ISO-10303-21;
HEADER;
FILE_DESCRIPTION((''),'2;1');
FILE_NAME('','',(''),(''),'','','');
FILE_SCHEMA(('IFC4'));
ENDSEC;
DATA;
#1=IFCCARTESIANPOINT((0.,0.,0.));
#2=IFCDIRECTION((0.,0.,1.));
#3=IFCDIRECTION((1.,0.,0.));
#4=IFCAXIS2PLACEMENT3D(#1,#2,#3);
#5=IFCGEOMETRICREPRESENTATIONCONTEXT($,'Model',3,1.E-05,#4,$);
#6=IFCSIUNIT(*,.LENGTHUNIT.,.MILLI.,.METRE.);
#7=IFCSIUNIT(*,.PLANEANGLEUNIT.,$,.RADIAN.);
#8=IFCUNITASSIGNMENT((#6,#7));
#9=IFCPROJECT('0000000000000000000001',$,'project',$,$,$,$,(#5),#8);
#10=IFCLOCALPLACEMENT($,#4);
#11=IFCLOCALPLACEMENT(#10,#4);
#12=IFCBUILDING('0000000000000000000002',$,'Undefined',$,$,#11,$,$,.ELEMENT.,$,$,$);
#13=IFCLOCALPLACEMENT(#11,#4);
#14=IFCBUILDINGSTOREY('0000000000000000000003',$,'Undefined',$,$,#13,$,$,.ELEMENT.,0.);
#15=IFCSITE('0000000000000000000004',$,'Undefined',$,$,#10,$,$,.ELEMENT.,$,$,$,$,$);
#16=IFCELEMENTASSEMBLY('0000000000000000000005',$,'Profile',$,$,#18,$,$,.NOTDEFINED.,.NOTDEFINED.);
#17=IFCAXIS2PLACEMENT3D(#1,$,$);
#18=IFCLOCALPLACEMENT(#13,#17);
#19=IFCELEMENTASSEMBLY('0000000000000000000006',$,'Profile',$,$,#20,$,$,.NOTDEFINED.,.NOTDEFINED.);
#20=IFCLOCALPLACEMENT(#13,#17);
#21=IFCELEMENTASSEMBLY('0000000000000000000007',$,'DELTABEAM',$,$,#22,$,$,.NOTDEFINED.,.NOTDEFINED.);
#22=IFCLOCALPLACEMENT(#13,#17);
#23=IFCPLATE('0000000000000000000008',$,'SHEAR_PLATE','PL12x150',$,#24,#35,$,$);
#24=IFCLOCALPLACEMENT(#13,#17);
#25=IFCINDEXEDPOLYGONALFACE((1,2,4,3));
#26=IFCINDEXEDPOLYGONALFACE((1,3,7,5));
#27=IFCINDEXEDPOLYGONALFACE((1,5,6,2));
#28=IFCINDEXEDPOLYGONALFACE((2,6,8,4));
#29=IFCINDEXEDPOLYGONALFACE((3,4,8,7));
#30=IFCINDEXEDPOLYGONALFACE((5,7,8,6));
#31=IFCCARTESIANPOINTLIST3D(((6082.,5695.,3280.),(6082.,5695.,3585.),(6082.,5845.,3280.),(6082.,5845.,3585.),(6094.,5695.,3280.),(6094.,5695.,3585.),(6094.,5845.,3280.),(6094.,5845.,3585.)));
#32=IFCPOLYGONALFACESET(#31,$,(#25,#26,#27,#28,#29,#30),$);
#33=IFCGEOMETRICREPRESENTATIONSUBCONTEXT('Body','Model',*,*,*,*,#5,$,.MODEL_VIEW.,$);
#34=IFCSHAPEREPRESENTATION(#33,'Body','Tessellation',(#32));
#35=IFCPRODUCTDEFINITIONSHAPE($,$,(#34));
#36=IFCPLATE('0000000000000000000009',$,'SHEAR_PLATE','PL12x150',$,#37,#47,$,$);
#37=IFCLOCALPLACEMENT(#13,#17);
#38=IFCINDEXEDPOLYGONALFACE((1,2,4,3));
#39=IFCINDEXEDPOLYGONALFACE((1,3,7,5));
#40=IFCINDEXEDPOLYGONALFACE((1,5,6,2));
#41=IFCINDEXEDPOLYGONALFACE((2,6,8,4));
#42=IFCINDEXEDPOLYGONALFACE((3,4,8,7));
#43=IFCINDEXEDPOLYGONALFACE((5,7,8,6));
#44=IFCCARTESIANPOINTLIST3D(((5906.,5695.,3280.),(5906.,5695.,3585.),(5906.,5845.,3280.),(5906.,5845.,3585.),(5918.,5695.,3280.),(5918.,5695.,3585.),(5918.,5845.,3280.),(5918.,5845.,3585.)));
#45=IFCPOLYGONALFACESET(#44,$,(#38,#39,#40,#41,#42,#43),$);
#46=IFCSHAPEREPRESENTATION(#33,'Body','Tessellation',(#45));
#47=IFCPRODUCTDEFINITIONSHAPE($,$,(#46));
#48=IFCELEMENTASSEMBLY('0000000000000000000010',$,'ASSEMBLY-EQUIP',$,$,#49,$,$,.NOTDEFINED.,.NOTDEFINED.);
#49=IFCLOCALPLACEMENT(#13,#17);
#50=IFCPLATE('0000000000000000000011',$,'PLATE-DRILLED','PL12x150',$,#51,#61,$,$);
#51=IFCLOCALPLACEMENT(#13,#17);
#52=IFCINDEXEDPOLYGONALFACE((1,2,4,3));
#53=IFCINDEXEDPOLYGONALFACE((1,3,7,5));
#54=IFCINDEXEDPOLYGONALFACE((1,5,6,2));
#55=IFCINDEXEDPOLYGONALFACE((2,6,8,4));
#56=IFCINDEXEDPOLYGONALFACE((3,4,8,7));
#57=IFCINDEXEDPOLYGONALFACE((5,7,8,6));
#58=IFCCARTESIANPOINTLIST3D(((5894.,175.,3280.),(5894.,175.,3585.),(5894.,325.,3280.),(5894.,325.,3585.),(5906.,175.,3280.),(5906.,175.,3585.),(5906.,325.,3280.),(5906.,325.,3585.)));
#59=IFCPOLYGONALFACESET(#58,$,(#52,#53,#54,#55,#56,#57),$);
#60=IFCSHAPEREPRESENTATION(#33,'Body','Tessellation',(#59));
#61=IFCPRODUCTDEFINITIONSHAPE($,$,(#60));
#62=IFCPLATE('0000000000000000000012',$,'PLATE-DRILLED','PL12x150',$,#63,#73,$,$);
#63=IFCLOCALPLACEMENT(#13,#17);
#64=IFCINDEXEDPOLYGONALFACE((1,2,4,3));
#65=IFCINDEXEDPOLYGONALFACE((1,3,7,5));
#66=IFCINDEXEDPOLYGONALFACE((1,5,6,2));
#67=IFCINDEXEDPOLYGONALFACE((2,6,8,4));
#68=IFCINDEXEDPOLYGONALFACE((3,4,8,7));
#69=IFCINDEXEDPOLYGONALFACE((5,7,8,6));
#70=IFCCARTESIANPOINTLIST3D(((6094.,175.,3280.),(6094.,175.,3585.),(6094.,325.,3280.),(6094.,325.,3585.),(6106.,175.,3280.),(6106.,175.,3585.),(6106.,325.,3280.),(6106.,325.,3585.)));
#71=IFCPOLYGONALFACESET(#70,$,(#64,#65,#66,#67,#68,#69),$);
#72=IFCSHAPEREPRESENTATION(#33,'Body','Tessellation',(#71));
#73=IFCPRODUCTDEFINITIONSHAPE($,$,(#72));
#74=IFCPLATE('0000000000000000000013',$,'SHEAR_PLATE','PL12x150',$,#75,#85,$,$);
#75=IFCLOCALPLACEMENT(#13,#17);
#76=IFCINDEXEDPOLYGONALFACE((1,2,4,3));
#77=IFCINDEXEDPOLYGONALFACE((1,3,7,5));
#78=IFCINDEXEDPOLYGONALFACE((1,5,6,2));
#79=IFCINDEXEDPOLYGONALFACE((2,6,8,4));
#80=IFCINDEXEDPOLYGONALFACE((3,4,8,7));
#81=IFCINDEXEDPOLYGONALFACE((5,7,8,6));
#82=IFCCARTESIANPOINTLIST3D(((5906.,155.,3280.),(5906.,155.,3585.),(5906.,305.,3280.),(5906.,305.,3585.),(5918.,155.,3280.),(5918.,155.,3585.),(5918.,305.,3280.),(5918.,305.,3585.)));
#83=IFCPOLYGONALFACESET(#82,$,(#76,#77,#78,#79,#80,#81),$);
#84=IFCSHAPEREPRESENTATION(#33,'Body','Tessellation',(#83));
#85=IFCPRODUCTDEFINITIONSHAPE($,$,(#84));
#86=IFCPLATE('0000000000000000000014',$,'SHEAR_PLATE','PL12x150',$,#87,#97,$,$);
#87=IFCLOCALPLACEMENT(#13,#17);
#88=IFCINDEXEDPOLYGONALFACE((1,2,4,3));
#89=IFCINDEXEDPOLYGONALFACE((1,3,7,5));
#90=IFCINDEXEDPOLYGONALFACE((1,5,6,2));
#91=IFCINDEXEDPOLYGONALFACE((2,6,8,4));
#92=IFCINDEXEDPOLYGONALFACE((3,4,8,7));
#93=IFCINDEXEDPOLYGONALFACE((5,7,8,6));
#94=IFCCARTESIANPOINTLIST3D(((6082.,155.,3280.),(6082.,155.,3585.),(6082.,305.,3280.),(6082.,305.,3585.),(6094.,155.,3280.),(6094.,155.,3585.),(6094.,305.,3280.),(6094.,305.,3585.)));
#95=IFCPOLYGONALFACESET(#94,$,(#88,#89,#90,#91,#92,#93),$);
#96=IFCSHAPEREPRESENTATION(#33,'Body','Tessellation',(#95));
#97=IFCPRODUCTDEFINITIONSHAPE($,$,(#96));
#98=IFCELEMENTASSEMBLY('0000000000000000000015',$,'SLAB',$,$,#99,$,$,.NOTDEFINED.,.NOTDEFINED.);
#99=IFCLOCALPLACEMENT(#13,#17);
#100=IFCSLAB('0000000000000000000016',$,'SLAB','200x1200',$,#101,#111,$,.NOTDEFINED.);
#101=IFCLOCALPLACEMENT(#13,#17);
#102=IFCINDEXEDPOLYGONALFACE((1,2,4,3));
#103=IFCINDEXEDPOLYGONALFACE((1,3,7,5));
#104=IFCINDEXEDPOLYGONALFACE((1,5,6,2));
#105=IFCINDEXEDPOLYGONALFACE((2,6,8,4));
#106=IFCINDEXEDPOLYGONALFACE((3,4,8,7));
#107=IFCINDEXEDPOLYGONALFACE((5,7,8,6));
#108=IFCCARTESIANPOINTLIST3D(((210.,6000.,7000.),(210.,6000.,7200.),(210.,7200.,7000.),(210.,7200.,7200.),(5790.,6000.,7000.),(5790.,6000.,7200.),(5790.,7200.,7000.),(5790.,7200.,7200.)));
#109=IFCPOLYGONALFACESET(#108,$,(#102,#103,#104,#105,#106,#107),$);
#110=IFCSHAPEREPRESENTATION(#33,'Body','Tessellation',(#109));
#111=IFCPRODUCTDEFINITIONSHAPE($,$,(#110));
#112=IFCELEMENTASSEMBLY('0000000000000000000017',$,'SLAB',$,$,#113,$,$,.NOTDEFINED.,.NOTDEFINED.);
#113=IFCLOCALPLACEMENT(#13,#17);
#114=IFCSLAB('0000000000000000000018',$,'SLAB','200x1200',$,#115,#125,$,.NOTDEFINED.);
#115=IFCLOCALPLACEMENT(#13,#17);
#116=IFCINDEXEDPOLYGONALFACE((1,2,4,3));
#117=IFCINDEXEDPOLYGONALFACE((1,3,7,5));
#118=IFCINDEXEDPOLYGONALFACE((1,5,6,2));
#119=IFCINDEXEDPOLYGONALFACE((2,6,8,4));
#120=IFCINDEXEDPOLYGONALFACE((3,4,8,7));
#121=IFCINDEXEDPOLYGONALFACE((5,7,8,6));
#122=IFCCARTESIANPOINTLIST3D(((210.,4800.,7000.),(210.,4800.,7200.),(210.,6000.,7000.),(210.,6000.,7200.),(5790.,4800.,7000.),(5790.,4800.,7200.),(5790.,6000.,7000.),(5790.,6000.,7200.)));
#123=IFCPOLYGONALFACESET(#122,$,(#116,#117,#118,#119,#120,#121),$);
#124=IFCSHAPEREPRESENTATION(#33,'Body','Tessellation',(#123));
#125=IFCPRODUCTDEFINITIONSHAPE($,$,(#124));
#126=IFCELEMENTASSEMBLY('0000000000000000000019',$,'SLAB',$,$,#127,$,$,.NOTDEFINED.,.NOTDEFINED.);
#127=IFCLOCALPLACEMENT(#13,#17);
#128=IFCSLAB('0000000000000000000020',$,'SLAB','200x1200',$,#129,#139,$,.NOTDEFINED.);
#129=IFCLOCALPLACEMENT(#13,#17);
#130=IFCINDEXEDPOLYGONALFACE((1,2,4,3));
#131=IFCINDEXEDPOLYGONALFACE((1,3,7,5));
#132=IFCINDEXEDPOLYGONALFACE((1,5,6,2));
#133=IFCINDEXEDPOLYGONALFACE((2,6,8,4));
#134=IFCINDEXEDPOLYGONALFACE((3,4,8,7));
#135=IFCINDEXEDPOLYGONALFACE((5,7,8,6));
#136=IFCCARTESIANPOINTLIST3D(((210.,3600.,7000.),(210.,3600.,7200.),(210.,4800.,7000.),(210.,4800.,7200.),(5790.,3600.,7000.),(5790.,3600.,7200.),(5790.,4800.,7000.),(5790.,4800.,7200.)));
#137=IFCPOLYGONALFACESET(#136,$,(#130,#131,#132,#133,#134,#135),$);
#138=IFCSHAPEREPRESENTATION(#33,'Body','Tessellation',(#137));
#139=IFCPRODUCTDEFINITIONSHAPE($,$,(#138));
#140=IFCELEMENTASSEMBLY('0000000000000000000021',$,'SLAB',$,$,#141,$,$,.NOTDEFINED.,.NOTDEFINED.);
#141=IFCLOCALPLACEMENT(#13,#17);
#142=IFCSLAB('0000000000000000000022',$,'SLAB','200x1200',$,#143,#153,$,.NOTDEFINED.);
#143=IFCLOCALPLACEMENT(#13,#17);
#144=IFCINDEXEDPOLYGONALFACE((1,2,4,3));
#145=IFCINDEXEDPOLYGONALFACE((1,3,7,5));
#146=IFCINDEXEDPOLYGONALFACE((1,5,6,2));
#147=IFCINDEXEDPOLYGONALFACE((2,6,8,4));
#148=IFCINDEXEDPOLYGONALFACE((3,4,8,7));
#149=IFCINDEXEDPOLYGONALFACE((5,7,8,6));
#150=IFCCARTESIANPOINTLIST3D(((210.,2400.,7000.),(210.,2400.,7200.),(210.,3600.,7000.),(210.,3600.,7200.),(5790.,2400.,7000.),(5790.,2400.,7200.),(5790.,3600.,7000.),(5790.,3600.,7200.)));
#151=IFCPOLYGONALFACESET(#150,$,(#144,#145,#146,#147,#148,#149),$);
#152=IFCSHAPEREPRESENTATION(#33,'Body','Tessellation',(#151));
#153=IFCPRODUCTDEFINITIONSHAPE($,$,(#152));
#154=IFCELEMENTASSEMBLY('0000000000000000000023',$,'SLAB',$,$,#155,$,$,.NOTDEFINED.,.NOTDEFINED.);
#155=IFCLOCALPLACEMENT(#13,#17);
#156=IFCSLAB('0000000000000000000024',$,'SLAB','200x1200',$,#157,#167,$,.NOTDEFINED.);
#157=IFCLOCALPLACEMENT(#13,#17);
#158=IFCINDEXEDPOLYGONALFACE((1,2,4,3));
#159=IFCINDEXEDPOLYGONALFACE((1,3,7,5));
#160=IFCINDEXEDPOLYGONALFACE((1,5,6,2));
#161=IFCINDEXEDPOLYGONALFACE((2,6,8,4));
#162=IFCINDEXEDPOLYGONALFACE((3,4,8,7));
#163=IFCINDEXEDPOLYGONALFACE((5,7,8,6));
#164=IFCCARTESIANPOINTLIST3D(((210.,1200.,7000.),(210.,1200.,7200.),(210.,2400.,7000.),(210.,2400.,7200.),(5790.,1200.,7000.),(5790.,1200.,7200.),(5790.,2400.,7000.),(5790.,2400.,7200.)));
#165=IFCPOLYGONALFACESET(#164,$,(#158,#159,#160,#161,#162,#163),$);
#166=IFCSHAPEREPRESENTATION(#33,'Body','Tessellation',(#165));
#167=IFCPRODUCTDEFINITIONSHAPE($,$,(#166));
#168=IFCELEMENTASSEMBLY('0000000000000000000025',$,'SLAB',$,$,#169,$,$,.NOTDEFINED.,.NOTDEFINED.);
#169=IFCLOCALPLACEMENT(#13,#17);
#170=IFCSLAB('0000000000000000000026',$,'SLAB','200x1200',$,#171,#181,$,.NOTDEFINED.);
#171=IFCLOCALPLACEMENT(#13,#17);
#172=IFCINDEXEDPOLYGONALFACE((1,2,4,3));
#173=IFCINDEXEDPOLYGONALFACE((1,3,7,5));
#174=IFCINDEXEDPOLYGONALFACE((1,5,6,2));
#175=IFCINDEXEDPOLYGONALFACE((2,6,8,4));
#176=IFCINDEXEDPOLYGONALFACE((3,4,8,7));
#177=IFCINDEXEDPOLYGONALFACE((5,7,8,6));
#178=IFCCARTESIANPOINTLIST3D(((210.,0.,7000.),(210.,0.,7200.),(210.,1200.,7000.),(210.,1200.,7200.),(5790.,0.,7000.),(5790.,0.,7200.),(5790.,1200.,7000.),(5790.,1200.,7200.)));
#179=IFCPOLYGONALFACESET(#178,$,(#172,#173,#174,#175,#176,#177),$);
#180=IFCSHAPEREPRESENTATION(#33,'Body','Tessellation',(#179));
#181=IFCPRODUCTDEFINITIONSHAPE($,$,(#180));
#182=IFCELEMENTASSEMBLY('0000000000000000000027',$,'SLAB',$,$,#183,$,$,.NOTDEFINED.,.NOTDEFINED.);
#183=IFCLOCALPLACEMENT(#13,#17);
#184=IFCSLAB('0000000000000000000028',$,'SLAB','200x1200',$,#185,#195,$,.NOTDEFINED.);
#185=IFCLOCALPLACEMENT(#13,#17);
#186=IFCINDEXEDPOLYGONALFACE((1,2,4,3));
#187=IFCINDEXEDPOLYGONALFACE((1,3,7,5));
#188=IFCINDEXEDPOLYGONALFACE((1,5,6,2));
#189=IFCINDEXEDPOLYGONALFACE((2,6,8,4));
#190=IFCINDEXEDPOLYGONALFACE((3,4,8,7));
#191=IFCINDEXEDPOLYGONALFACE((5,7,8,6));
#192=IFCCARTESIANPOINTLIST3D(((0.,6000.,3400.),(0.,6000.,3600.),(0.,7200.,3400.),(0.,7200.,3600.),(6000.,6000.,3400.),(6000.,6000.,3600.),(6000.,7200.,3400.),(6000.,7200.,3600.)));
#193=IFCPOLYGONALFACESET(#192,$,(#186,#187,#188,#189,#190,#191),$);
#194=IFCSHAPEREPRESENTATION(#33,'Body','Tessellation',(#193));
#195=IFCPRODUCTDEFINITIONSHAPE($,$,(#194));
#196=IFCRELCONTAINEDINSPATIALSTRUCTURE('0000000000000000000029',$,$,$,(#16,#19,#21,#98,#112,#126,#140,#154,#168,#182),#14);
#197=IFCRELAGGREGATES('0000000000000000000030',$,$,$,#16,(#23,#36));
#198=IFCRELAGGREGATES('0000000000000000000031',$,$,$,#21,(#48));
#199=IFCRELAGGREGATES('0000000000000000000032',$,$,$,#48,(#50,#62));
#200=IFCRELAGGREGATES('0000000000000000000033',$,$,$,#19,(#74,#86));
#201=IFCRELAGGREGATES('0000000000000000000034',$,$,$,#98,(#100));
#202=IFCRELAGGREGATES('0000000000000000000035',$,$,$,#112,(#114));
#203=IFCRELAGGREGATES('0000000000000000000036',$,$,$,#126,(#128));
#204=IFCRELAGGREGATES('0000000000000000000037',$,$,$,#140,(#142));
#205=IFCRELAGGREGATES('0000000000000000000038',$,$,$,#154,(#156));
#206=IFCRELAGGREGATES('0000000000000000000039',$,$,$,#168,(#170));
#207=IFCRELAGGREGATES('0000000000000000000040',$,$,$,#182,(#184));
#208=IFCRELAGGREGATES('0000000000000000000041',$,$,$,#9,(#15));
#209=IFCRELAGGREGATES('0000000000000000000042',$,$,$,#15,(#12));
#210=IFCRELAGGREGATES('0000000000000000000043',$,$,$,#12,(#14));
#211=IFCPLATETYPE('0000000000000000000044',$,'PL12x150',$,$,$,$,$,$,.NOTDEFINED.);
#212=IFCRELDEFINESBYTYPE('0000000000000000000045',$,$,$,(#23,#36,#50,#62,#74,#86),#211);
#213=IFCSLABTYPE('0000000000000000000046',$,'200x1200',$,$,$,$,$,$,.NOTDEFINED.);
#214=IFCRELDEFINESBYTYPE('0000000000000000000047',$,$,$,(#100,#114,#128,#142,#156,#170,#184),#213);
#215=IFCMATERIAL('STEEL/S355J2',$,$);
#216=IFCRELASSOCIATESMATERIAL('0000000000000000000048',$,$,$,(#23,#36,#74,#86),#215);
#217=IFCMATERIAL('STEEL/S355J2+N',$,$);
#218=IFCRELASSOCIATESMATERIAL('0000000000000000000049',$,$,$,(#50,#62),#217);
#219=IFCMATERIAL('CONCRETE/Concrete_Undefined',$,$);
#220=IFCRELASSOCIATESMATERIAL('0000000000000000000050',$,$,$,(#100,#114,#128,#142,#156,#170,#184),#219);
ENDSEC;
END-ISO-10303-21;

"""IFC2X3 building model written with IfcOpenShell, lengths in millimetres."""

from ifc_helpers import new_model, si_unit, frame, origin_with_axes, place, context, subcontext, project, spatial, polyline, outline, extrude, material, type_object, element, aggregate, save


model = new_model("IFC2X3")

# Units and contexts
model_context = context("Model", 3, precision=1e-05, world=origin_with_axes())
body_context = subcontext(model_context, "Body", "Model", "MODEL_VIEW")
ifc_project = project(units=[si_unit("LENGTHUNIT", "METRE", prefix="MILLI"), si_unit("PLANEANGLEUNIT", "RADIAN")], contexts=[model_context])

# Site, building, storey
site_placement = place(None, origin_with_axes())
site = spatial("IfcSite", under=ifc_project, at=site_placement, Name="Undefined", CompositionType="ELEMENT")
building_placement = place(site_placement, origin_with_axes())
building = spatial("IfcBuilding", under=site, at=building_placement, Name="Undefined", CompositionType="ELEMENT")
storey_placement = place(building_placement, origin_with_axes())
storey = spatial("IfcBuildingStorey", under=building, at=storey_placement, Name="Undefined", CompositionType="ELEMENT", Elevation=0.0)

# Element assembly
assembly_1_placement = place(storey_placement, origin_with_axes())
assembly_1 = element("IfcElementAssembly", 1, at=assembly_1_placement, inside=storey, Name="Profile", AssemblyPlace="NOTDEFINED", PredefinedType="NOTDEFINED")
ifc_material_1 = material(Name="STEEL/S355J2")

# Element assembly
assembly_2_placement = place(storey_placement, origin_with_axes())
assembly_2 = element("IfcElementAssembly", 2, at=assembly_2_placement, inside=storey, Name="Profile", AssemblyPlace="NOTDEFINED", PredefinedType="NOTDEFINED")

# Shared definitions
ifc_material_2 = material(Name="STEEL/S355J2+N")
plate_type_1 = type_object("IfcPlateType", Name="PL12x150", PredefinedType="NOTDEFINED")

# Element assembly
assembly_3_placement = place(storey_placement, origin_with_axes())
assembly_3 = element("IfcElementAssembly", 3, at=assembly_3_placement, inside=storey, Name="DELTABEAM", AssemblyPlace="NOTDEFINED", PredefinedType="NOTDEFINED")

# Plates
plate_1_placement = place(assembly_1_placement, frame((6088.0, 5845.0, 3585.0), z_axis=(1.0, 0.0, 0.0), x_axis=(0.0, -1.0, 0.0)))
plate_1 = element("IfcPlate", 4, at=plate_1_placement, type_object=plate_type_1, material=ifc_material_1, Name="SHEAR_PLATE", Description="PL12x150", context=body_context, shape_type="SweptSolid", body=[
    extrude(outline(polyline([(0.0, 0.0), (150.0, 0.0), (150.0, 0.0), (150.0, 305.0), (150.0, 305.0), (0.0, 305.0), (0.0, 305.0), (0.0, 0.0)])), frame((0.0, 0.0, -6.0), z_axis=(0.0, 0.0, 1.0), x_axis=(1.0, 0.0, 0.0)), (0.0, 0.0, 1.0), 12.0),
])
plate_2_placement = place(assembly_1_placement, frame((5912.0, 5845.0, 3585.0), z_axis=(1.0, 0.0, 0.0), x_axis=(0.0, -1.0, 0.0)))
plate_2 = element("IfcPlate", 5, at=plate_2_placement, type_object=plate_type_1, material=ifc_material_1, Name="SHEAR_PLATE", Description="PL12x150", context=body_context, shape_type="SweptSolid", body=[
    extrude(outline(polyline([(0.0, 0.0), (150.0, 0.0), (150.0, 0.0), (150.0, 305.0), (150.0, 305.0), (0.0, 305.0), (0.0, 305.0), (0.0, 0.0)])), frame((0.0, 0.0, -6.0), z_axis=(0.0, 0.0, 1.0), x_axis=(1.0, 0.0, 0.0)), (0.0, 0.0, 1.0), 12.0),
])
aggregate(assembly_1, [plate_1, plate_2])

# Element assembly
assembly_4_placement = place(assembly_3_placement, origin_with_axes())
assembly_4 = element("IfcElementAssembly", 6, at=assembly_4_placement, Name="ASSEMBLY-EQUIP", AssemblyPlace="NOTDEFINED", PredefinedType="NOTDEFINED")
aggregate(assembly_3, [assembly_4])

# Plates
plate_3_placement = place(assembly_4_placement, frame((5900.0, 325.0, 3585.0), z_axis=(1.0, 0.0, 0.0), x_axis=(0.0, -1.0, 0.0)))
plate_3 = element("IfcPlate", 7, at=plate_3_placement, type_object=plate_type_1, material=ifc_material_2, Name="PLATE-DRILLED", Description="PL12x150", context=body_context, shape_type="SweptSolid", body=[
    extrude(outline(polyline([(0.0, 0.0), (150.0, 0.0), (150.0, 0.0), (150.0, 305.0), (150.0, 305.0), (0.0, 305.0), (0.0, 305.0), (0.0, 0.0)])), frame((0.0, 0.0, -6.0), z_axis=(0.0, 0.0, 1.0), x_axis=(1.0, 0.0, 0.0)), (0.0, 0.0, 1.0), 12.0),
])
plate_4_placement = place(assembly_4_placement, frame((6100.0, 325.0, 3585.0), z_axis=(1.0, 0.0, 0.0), x_axis=(0.0, -1.0, 0.0)))
plate_4 = element("IfcPlate", 8, at=plate_4_placement, type_object=plate_type_1, material=ifc_material_2, Name="PLATE-DRILLED", Description="PL12x150", context=body_context, shape_type="SweptSolid", body=[
    extrude(outline(polyline([(0.0, 0.0), (150.0, 0.0), (150.0, 0.0), (150.0, 305.0), (150.0, 305.0), (0.0, 305.0), (0.0, 305.0), (0.0, 0.0)])), frame((0.0, 0.0, -6.0), z_axis=(0.0, 0.0, 1.0), x_axis=(1.0, 0.0, 0.0)), (0.0, 0.0, 1.0), 12.0),
])
aggregate(assembly_4, [plate_3, plate_4])
plate_5_placement = place(assembly_2_placement, frame((5912.0, 155.0, 3585.0), z_axis=(-1.0, 0.0, 0.0), x_axis=(0.0, 1.0, 0.0)))
plate_5 = element("IfcPlate", 9, at=plate_5_placement, type_object=plate_type_1, material=ifc_material_1, Name="SHEAR_PLATE", Description="PL12x150", context=body_context, shape_type="SweptSolid", body=[
    extrude(outline(polyline([(0.0, 0.0), (150.0, 0.0), (150.0, 0.0), (150.0, 305.0), (150.0, 305.0), (0.0, 305.0), (0.0, 305.0), (0.0, 0.0)])), frame((0.0, 0.0, -6.0), z_axis=(0.0, 0.0, 1.0), x_axis=(1.0, 0.0, 0.0)), (0.0, 0.0, 1.0), 12.0),
])
plate_6_placement = place(assembly_2_placement, frame((6088.0, 155.0, 3585.0), z_axis=(-1.0, 0.0, 0.0), x_axis=(0.0, 1.0, 0.0)))
plate_6 = element("IfcPlate", 10, at=plate_6_placement, type_object=plate_type_1, material=ifc_material_1, Name="SHEAR_PLATE", Description="PL12x150", context=body_context, shape_type="SweptSolid", body=[
    extrude(outline(polyline([(0.0, 0.0), (150.0, 0.0), (150.0, 0.0), (150.0, 305.0), (150.0, 305.0), (0.0, 305.0), (0.0, 305.0), (0.0, 0.0)])), frame((0.0, 0.0, -6.0), z_axis=(0.0, 0.0, 1.0), x_axis=(1.0, 0.0, 0.0)), (0.0, 0.0, 1.0), 12.0),
])
aggregate(assembly_2, [plate_5, plate_6])

# Element assemblies, slabs
assembly_5_placement = place(storey_placement, origin_with_axes())
assembly_5 = element("IfcElementAssembly", 11, at=assembly_5_placement, inside=storey, Name="SLAB", AssemblyPlace="NOTDEFINED", PredefinedType="NOTDEFINED")
ifc_material_3 = material(Name="CONCRETE/Concrete_Undefined")
slab_type = type_object("IfcSlabType", Name="200x1200", PredefinedType="NOTDEFINED")
slab_1_placement = place(assembly_5_placement, frame((5790.0, 6000.0, 7100.0), z_axis=(0.0, 0.0, 1.0), x_axis=(0.0, 1.0, 0.0)))
slab_1 = element("IfcSlab", 12, at=slab_1_placement, type_object=slab_type, material=ifc_material_3, Name="SLAB", Description="200x1200", PredefinedType="NOTDEFINED", context=body_context, shape_type="SweptSolid", body=[
    extrude(outline(polyline([(0.0, 0.0), (1200.0, 0.0), (1200.0, 5580.0), (0.0, 5580.0), (0.0, 0.0)])), frame((0.0, 0.0, -100.0), z_axis=(0.0, 0.0, 1.0), x_axis=(1.0, 0.0, 0.0)), (0.0, 0.0, 1.0), 200.0),
])
aggregate(assembly_5, [slab_1])
assembly_6_placement = place(storey_placement, origin_with_axes())
assembly_6 = element("IfcElementAssembly", 13, at=assembly_6_placement, inside=storey, Name="SLAB", AssemblyPlace="NOTDEFINED", PredefinedType="NOTDEFINED")
slab_2_placement = place(assembly_6_placement, frame((5790.0, 4800.0, 7100.0), z_axis=(0.0, 0.0, 1.0), x_axis=(0.0, 1.0, 0.0)))
slab_2 = element("IfcSlab", 14, at=slab_2_placement, type_object=slab_type, material=ifc_material_3, Name="SLAB", Description="200x1200", PredefinedType="NOTDEFINED", context=body_context, shape_type="SweptSolid", body=[
    extrude(outline(polyline([(0.0, 0.0), (1200.0, 0.0), (1200.0, 5580.0), (0.0, 5580.0), (0.0, 0.0)])), frame((0.0, 0.0, -100.0), z_axis=(0.0, 0.0, 1.0), x_axis=(1.0, 0.0, 0.0)), (0.0, 0.0, 1.0), 200.0),
])
aggregate(assembly_6, [slab_2])
assembly_7_placement = place(storey_placement, origin_with_axes())
assembly_7 = element("IfcElementAssembly", 15, at=assembly_7_placement, inside=storey, Name="SLAB", AssemblyPlace="NOTDEFINED", PredefinedType="NOTDEFINED")
slab_3_placement = place(assembly_7_placement, frame((5790.0, 3600.0, 7100.0), z_axis=(0.0, 0.0, 1.0), x_axis=(0.0, 1.0, 0.0)))
slab_3 = element("IfcSlab", 16, at=slab_3_placement, type_object=slab_type, material=ifc_material_3, Name="SLAB", Description="200x1200", PredefinedType="NOTDEFINED", context=body_context, shape_type="SweptSolid", body=[
    extrude(outline(polyline([(0.0, 0.0), (1200.0, 0.0), (1200.0, 5580.0), (0.0, 5580.0), (0.0, 0.0)])), frame((0.0, 0.0, -100.0), z_axis=(0.0, 0.0, 1.0), x_axis=(1.0, 0.0, 0.0)), (0.0, 0.0, 1.0), 200.0),
])
aggregate(assembly_7, [slab_3])
assembly_8_placement = place(storey_placement, origin_with_axes())
assembly_8 = element("IfcElementAssembly", 17, at=assembly_8_placement, inside=storey, Name="SLAB", AssemblyPlace="NOTDEFINED", PredefinedType="NOTDEFINED")
slab_4_placement = place(assembly_8_placement, frame((5790.0, 2400.0, 7100.0), z_axis=(0.0, 0.0, 1.0), x_axis=(0.0, 1.0, 0.0)))
slab_4 = element("IfcSlab", 18, at=slab_4_placement, type_object=slab_type, material=ifc_material_3, Name="SLAB", Description="200x1200", PredefinedType="NOTDEFINED", context=body_context, shape_type="SweptSolid", body=[
    extrude(outline(polyline([(0.0, 0.0), (1200.0, 0.0), (1200.0, 5580.0), (0.0, 5580.0), (0.0, 0.0)])), frame((0.0, 0.0, -100.0), z_axis=(0.0, 0.0, 1.0), x_axis=(1.0, 0.0, 0.0)), (0.0, 0.0, 1.0), 200.0),
])
aggregate(assembly_8, [slab_4])
assembly_9_placement = place(storey_placement, origin_with_axes())
assembly_9 = element("IfcElementAssembly", 19, at=assembly_9_placement, inside=storey, Name="SLAB", AssemblyPlace="NOTDEFINED", PredefinedType="NOTDEFINED")
slab_5_placement = place(assembly_9_placement, frame((5790.0, 1200.0, 7100.0), z_axis=(0.0, 0.0, 1.0), x_axis=(0.0, 1.0, 0.0)))
slab_5 = element("IfcSlab", 20, at=slab_5_placement, type_object=slab_type, material=ifc_material_3, Name="SLAB", Description="200x1200", PredefinedType="NOTDEFINED", context=body_context, shape_type="SweptSolid", body=[
    extrude(outline(polyline([(0.0, 0.0), (1200.0, 0.0), (1200.0, 5580.0), (0.0, 5580.0), (0.0, 0.0)])), frame((0.0, 0.0, -100.0), z_axis=(0.0, 0.0, 1.0), x_axis=(1.0, 0.0, 0.0)), (0.0, 0.0, 1.0), 200.0),
])
aggregate(assembly_9, [slab_5])
assembly_10_placement = place(storey_placement, origin_with_axes())
assembly_10 = element("IfcElementAssembly", 21, at=assembly_10_placement, inside=storey, Name="SLAB", AssemblyPlace="NOTDEFINED", PredefinedType="NOTDEFINED")
slab_6_placement = place(assembly_10_placement, frame((5790.0, 0.0, 7100.0), z_axis=(0.0, 0.0, 1.0), x_axis=(0.0, 1.0, 0.0)))
slab_6 = element("IfcSlab", 22, at=slab_6_placement, type_object=slab_type, material=ifc_material_3, Name="SLAB", Description="200x1200", PredefinedType="NOTDEFINED", context=body_context, shape_type="SweptSolid", body=[
    extrude(outline(polyline([(0.0, 0.0), (1200.0, 0.0), (1200.0, 5580.0), (0.0, 5580.0), (0.0, 0.0)])), frame((0.0, 0.0, -100.0), z_axis=(0.0, 0.0, 1.0), x_axis=(1.0, 0.0, 0.0)), (0.0, 0.0, 1.0), 200.0),
])
aggregate(assembly_10, [slab_6])
assembly_11_placement = place(storey_placement, origin_with_axes())
assembly_11 = element("IfcElementAssembly", 23, at=assembly_11_placement, inside=storey, Name="SLAB", AssemblyPlace="NOTDEFINED", PredefinedType="NOTDEFINED")
slab_7_placement = place(assembly_11_placement, frame((6000.0, 6000.0, 3500.0), z_axis=(0.0, 0.0, 1.0), x_axis=(0.0, 1.0, 0.0)))
slab_7 = element("IfcSlab", 24, at=slab_7_placement, type_object=slab_type, material=ifc_material_3, Name="SLAB", Description="200x1200", PredefinedType="NOTDEFINED", context=body_context, shape_type="SweptSolid", body=[
    extrude(outline(polyline([(0.0, 0.0), (1200.0, 0.0), (1200.0, 6000.0), (0.0, 6000.0), (0.0, 0.0)])), frame((0.0, 0.0, -100.0), z_axis=(0.0, 0.0, 1.0), x_axis=(1.0, 0.0, 0.0)), (0.0, 0.0, 1.0), 200.0),
])
aggregate(assembly_11, [slab_7])

save(model, "model.ifc")
